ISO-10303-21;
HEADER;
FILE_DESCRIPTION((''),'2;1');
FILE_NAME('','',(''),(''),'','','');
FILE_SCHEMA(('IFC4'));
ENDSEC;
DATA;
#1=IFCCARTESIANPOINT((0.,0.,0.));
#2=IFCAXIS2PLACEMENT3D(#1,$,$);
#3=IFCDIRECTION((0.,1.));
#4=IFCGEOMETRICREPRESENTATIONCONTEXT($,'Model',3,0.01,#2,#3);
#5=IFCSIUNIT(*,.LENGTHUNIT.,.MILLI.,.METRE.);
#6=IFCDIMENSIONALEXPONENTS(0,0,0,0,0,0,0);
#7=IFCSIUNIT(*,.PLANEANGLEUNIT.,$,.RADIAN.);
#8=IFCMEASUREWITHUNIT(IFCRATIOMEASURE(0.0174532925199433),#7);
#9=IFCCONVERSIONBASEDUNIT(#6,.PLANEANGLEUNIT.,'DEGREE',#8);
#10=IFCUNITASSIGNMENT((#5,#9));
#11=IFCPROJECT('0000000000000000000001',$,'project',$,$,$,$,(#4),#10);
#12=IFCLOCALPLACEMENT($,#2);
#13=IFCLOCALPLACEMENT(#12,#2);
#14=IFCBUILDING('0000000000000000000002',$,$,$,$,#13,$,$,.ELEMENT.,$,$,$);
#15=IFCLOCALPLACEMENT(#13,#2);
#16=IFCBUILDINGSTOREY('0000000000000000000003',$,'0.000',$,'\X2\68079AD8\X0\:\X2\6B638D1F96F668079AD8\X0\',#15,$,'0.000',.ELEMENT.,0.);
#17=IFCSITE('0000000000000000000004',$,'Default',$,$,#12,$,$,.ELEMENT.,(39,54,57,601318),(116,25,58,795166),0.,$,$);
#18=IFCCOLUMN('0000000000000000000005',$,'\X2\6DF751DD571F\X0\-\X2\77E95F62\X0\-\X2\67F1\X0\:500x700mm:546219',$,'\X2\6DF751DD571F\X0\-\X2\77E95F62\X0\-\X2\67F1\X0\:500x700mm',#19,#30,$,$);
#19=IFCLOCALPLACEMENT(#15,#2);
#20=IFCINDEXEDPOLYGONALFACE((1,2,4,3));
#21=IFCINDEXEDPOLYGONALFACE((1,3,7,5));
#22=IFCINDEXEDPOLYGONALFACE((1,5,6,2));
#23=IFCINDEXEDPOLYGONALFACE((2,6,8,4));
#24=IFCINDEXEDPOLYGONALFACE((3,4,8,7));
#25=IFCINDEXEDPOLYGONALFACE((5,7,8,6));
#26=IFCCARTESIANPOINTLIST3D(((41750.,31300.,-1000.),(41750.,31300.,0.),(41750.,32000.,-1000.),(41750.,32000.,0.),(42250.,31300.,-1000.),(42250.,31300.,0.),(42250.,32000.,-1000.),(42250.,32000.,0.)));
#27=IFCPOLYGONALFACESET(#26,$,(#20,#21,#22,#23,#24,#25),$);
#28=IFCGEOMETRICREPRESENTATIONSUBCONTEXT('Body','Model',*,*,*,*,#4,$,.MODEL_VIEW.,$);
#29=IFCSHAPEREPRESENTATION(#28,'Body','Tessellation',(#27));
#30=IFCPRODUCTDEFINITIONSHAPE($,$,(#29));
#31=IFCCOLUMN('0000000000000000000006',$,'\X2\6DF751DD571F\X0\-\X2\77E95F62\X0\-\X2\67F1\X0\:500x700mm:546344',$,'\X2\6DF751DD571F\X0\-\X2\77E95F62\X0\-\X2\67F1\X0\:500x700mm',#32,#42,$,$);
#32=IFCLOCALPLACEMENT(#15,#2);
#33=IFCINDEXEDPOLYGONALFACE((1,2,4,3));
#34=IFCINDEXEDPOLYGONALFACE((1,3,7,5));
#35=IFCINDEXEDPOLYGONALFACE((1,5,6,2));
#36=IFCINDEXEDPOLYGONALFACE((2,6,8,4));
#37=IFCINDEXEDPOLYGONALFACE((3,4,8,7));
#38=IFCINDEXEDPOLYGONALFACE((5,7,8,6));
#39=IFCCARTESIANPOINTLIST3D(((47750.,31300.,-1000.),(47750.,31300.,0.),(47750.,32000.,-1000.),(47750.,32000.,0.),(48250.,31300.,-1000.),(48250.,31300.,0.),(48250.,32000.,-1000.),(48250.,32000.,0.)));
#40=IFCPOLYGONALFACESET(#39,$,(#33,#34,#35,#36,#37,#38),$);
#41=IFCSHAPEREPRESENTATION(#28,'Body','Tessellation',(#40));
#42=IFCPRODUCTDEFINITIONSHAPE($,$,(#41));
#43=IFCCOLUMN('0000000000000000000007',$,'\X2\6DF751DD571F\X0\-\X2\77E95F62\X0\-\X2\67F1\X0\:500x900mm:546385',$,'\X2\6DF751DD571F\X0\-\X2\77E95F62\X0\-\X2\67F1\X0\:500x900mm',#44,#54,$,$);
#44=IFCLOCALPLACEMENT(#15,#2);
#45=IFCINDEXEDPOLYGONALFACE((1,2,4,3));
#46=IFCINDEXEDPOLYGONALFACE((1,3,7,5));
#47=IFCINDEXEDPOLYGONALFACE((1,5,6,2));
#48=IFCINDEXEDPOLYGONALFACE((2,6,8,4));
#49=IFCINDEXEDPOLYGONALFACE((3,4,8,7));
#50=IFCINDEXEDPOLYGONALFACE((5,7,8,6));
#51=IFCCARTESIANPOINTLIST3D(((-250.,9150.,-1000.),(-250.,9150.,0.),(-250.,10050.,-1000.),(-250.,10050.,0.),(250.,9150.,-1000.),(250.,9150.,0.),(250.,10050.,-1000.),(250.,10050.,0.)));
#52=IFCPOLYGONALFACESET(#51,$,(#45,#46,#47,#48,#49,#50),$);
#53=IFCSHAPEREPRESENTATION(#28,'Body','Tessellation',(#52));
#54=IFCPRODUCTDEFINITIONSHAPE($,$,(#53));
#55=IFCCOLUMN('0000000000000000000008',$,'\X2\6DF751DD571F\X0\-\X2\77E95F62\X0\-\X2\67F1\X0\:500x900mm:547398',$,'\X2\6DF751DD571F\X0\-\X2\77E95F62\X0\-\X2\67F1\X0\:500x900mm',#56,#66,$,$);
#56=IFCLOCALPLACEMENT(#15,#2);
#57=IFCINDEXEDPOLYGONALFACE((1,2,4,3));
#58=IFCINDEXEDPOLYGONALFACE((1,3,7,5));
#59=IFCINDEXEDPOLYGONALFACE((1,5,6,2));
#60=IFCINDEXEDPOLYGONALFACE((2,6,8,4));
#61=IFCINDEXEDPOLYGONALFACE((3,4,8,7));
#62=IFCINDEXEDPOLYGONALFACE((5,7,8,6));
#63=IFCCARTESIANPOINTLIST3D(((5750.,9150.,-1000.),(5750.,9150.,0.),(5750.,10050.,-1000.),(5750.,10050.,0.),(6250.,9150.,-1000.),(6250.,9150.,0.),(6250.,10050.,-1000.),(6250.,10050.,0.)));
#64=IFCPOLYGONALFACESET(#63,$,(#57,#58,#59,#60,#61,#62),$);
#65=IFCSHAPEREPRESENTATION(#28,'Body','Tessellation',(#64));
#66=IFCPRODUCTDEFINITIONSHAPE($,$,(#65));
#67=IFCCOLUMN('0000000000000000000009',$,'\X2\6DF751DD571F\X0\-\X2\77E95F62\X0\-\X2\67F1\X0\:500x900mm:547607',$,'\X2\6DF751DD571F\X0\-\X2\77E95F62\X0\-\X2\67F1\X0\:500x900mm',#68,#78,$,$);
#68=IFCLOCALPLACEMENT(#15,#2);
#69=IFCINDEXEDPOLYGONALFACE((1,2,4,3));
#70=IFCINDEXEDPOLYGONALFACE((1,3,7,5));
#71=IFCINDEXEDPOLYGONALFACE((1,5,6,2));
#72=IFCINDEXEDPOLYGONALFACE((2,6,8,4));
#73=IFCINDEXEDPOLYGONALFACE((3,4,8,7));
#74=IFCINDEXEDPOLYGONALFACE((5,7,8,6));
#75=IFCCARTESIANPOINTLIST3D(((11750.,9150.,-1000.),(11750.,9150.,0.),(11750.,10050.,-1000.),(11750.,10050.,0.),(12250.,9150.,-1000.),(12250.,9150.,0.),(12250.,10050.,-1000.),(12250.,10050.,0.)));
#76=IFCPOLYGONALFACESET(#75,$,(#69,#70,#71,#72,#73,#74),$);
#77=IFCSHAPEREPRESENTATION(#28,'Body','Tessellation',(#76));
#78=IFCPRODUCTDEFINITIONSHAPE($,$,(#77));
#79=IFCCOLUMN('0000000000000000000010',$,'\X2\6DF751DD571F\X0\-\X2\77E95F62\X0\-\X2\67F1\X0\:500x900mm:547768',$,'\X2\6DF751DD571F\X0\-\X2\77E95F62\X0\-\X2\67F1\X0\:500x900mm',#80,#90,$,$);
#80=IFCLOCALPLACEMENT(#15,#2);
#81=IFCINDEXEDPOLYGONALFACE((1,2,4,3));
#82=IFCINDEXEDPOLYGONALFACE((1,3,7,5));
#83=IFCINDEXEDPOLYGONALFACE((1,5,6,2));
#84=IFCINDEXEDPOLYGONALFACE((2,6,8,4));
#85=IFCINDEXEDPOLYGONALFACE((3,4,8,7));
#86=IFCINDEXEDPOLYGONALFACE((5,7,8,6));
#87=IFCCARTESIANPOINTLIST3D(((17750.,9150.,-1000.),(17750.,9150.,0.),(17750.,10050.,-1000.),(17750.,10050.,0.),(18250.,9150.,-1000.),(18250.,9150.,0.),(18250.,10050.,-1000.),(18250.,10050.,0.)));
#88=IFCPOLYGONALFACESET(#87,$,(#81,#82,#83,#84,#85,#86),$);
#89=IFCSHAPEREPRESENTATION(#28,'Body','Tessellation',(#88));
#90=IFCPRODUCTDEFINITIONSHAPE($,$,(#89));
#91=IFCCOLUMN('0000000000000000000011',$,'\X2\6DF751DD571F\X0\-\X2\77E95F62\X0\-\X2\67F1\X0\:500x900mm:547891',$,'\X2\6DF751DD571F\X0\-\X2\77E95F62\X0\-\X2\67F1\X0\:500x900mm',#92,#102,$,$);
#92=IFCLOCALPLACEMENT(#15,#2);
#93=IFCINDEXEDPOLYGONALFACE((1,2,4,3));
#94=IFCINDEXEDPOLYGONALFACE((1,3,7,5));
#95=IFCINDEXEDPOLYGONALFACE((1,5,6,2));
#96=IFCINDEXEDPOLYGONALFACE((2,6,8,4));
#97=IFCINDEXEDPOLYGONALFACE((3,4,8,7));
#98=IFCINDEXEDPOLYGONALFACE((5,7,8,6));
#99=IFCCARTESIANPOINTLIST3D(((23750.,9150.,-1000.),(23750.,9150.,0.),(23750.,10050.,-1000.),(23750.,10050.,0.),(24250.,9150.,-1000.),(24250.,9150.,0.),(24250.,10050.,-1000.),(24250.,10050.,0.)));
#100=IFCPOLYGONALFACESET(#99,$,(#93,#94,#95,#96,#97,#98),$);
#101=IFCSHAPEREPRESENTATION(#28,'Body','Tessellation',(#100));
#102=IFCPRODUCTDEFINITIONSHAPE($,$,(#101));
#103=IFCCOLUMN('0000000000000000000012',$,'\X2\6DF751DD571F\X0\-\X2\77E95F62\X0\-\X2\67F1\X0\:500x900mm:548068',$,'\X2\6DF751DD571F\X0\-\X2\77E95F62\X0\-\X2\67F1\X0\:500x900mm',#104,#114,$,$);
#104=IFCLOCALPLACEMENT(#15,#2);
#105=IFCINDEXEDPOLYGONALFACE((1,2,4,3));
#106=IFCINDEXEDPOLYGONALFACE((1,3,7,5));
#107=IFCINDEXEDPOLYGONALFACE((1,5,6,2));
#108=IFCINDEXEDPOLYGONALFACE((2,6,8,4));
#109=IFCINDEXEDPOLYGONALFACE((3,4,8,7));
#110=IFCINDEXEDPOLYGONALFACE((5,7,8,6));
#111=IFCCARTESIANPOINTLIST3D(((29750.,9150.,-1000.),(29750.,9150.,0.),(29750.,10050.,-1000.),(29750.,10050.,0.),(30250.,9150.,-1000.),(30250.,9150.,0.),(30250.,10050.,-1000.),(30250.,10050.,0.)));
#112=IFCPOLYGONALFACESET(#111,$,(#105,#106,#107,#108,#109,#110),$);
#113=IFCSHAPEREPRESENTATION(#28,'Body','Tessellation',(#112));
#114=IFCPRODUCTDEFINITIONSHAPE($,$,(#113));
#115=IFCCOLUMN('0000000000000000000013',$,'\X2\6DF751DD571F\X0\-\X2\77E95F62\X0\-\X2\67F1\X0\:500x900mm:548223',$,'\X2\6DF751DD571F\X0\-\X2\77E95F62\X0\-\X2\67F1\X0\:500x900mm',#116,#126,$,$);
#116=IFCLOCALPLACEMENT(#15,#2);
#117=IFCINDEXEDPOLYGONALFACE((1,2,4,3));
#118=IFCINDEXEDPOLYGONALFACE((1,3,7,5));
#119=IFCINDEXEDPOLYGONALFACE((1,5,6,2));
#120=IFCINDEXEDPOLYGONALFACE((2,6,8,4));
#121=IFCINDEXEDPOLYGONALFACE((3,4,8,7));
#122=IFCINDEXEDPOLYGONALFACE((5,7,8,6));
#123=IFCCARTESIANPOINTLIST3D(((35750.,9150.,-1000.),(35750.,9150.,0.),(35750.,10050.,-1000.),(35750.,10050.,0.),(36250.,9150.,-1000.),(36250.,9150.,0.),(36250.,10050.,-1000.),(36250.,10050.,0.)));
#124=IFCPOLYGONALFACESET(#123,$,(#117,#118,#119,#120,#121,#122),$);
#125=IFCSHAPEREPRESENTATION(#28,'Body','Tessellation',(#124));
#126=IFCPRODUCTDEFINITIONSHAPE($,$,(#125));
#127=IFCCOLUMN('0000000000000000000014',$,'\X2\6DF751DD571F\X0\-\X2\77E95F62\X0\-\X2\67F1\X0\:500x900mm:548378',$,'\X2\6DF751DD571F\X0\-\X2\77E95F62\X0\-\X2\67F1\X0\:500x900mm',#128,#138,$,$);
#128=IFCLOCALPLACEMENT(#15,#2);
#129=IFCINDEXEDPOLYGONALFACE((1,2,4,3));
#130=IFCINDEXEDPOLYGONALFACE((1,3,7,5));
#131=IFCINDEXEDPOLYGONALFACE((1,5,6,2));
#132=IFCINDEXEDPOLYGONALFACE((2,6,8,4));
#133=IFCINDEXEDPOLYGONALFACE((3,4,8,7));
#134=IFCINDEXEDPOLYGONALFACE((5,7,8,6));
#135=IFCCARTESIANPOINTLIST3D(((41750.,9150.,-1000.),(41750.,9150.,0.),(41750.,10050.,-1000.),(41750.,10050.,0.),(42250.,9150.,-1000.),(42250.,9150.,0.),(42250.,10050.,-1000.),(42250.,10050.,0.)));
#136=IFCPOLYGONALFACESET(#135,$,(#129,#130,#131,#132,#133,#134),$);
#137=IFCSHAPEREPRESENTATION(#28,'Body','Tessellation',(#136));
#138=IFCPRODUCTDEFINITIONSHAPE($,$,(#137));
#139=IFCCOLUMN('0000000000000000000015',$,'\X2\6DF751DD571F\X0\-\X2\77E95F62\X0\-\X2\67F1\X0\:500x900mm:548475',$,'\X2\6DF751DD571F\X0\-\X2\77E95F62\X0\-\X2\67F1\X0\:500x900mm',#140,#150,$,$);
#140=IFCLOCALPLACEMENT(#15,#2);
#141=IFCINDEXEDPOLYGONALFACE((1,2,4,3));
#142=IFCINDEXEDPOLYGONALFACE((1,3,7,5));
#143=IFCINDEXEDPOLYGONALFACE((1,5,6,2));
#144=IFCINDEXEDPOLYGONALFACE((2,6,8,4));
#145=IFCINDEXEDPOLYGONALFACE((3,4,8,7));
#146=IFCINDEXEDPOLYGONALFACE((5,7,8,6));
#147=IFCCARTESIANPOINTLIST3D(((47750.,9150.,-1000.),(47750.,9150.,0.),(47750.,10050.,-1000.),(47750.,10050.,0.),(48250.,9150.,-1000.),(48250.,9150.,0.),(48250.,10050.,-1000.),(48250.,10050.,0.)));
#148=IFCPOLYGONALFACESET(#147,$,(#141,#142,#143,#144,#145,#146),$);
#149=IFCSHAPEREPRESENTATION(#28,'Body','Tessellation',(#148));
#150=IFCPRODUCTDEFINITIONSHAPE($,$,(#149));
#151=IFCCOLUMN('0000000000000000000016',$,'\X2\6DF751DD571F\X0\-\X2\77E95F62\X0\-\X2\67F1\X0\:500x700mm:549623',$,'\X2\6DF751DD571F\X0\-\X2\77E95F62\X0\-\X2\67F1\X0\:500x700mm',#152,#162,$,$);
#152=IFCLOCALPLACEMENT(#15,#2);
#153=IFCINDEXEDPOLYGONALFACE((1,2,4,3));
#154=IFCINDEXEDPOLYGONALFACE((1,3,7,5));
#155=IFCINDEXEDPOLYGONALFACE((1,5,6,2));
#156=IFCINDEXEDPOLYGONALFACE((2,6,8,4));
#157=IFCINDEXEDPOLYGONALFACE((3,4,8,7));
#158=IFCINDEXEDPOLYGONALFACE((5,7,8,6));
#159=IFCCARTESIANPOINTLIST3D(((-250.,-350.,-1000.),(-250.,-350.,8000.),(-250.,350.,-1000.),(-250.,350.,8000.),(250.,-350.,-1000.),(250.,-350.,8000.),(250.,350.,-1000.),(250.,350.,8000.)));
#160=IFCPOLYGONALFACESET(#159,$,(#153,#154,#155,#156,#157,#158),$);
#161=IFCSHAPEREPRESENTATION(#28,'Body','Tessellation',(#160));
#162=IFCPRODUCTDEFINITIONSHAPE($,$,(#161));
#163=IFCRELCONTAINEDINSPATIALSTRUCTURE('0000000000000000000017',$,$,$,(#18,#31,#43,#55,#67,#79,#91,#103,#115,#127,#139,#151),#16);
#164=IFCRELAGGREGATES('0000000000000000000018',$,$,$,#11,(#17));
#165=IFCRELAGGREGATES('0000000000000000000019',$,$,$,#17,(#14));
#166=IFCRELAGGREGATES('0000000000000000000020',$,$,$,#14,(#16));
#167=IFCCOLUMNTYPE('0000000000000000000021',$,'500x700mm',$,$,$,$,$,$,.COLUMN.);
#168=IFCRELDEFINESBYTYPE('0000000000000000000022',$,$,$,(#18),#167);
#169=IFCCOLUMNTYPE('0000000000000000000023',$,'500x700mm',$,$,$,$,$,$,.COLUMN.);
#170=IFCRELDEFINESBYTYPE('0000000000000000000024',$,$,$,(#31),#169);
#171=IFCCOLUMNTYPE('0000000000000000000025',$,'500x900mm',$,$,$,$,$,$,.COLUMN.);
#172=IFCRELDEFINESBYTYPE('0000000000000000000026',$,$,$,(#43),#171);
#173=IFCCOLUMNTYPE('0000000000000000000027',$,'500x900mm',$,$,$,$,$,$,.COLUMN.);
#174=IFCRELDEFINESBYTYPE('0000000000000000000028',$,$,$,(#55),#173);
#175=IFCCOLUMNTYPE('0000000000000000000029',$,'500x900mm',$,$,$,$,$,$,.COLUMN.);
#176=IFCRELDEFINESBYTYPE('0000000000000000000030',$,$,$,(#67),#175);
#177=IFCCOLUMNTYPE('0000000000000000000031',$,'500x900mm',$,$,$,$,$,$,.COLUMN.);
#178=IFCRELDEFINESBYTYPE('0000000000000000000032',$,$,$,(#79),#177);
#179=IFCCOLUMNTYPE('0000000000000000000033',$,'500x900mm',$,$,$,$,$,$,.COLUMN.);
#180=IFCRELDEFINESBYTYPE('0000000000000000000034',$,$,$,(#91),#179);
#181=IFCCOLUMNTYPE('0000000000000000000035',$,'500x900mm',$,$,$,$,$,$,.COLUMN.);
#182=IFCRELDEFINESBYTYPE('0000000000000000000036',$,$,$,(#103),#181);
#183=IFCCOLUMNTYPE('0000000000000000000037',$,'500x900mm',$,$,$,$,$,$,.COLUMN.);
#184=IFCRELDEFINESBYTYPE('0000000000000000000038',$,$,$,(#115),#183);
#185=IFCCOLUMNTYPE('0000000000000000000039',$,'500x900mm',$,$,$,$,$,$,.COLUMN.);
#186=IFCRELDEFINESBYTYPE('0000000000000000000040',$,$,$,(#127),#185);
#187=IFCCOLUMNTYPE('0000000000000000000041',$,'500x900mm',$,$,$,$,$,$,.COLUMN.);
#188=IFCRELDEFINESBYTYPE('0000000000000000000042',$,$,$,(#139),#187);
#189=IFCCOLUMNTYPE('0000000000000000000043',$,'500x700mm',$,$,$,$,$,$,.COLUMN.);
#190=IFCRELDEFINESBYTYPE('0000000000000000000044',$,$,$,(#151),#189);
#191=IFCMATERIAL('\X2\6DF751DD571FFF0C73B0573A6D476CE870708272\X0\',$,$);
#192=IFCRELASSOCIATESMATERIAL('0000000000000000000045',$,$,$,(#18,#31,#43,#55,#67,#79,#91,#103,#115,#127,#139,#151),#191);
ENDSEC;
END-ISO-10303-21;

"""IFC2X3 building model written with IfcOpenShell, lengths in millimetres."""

from ifc_helpers import new_model, entity, si_unit, converted_unit, direction, frame, frame_2d, origin, origin_2d_with_axis, place, context, subcontext, project, spatial, rectangle, extrude, source, transform, mapped, material, type_object, type_shapes, element, save


model = new_model("IFC2X3")

# Units and contexts
model_context = context("Model", 3, precision=0.01, world=origin(), true_north=direction((0.0, 1.0)))
body_context = subcontext(model_context, "Body", "Model", "MODEL_VIEW")
ifc_project = project(units=[si_unit("LENGTHUNIT", "METRE", prefix="MILLI"), converted_unit("PLANEANGLEUNIT", "DEGREE", entity("IfcRatioMeasure", 0.0174532925199433), si_unit("PLANEANGLEUNIT", "RADIAN"), dimensions=[0, 0, 0, 0, 0, 0, 0])], contexts=[model_context])

# Site, building, storey
site_placement = place(None, origin())
site = spatial("IfcSite", under=ifc_project, at=site_placement, Name="Default", CompositionType="ELEMENT", RefLatitude=(39, 54, 57, 601318), RefLongitude=(116, 25, 58, 795166), RefElevation=0.0)
building_placement = place(site_placement, origin())
building = spatial("IfcBuilding", under=site, at=building_placement, CompositionType="ELEMENT")
storey_placement = place(building_placement, origin())
storey = spatial("IfcBuildingStorey", under=building, at=storey_placement, Name="0.000", ObjectType="标高:正负零标高", LongName="0.000", CompositionType="ELEMENT", Elevation=0.0)

# Columns
ifc_material_1 = material(Name="混凝土，现场浇注灰色")
column_type_1 = type_object("IfcColumnType", Name="500x700mm", PredefinedType="COLUMN")
shared_shape_1 = source(origin(), body_context, "Body", "SweptSolid", [
    extrude(rectangle(XDim=700.0, YDim=500.0, at=origin_2d_with_axis()), frame((42000.0, 31650.0, -1000.0), z_axis=(0.0, 0.0, 1.0), x_axis=(0.0, -1.0, 0.0)), (0.0, 0.0, 1.0), 1000.0),
])
type_shapes(column_type_1, [shared_shape_1])
column_1_placement = place(storey_placement, origin())
element("IfcColumn", 1, at=column_1_placement, inside=storey, type_object=column_type_1, material=ifc_material_1, Name="混凝土-矩形-柱:500x700mm:546219", ObjectType="混凝土-矩形-柱:500x700mm", context=body_context, shape_type="MappedRepresentation", body=[
    mapped(shared_shape_1, transform((0.0, 0.0, 0.0), scale=1.0)),
])
column_type_2 = type_object("IfcColumnType", Name="500x700mm", PredefinedType="COLUMN")
shared_shape_2 = source(origin(), body_context, "Body", "SweptSolid", [
    extrude(rectangle(XDim=700.0, YDim=500.0, at=origin_2d_with_axis()), frame((48000.0, 31650.0, -1000.0), z_axis=(0.0, 0.0, 1.0), x_axis=(0.0, -1.0, 0.0)), (0.0, 0.0, 1.0), 1000.0),
])
type_shapes(column_type_2, [shared_shape_2])
column_2_placement = place(storey_placement, origin())
element("IfcColumn", 2, at=column_2_placement, inside=storey, type_object=column_type_2, material=ifc_material_1, Name="混凝土-矩形-柱:500x700mm:546344", ObjectType="混凝土-矩形-柱:500x700mm", context=body_context, shape_type="MappedRepresentation", body=[
    mapped(shared_shape_2, transform((0.0, 0.0, 0.0), scale=1.0)),
])
column_type_3 = type_object("IfcColumnType", Name="500x900mm", PredefinedType="COLUMN")
shared_shape_3 = source(origin(), body_context, "Body", "SweptSolid", [
    extrude(rectangle(XDim=900.0, YDim=500.0, at=origin_2d_with_axis()), frame((0.0, 9600.0, -1000.0), z_axis=(0.0, 0.0, 1.0), x_axis=(0.0, -1.0, 0.0)), (0.0, 0.0, 1.0), 1000.0),
])
type_shapes(column_type_3, [shared_shape_3])
column_3_placement = place(storey_placement, origin())
element("IfcColumn", 3, at=column_3_placement, inside=storey, type_object=column_type_3, material=ifc_material_1, Name="混凝土-矩形-柱:500x900mm:546385", ObjectType="混凝土-矩形-柱:500x900mm", context=body_context, shape_type="MappedRepresentation", body=[
    mapped(shared_shape_3, transform((0.0, 0.0, 0.0), scale=1.0)),
])
column_type_4 = type_object("IfcColumnType", Name="500x900mm", PredefinedType="COLUMN")
shared_shape_4 = source(origin(), body_context, "Body", "SweptSolid", [
    extrude(rectangle(XDim=900.0, YDim=500.0, at=frame_2d((0.0, 0.0), x_axis=(1.0, 0.0))), frame((6000.0, 9600.0, -1000.0), z_axis=(0.0, 0.0, 1.0), x_axis=(0.0, -1.0, 0.0)), (0.0, 0.0, 1.0), 1000.0),
])
type_shapes(column_type_4, [shared_shape_4])
column_4_placement = place(storey_placement, origin())
element("IfcColumn", 4, at=column_4_placement, inside=storey, type_object=column_type_4, material=ifc_material_1, Name="混凝土-矩形-柱:500x900mm:547398", ObjectType="混凝土-矩形-柱:500x900mm", context=body_context, shape_type="MappedRepresentation", body=[
    mapped(shared_shape_4, transform((0.0, 0.0, 0.0), scale=1.0)),
])
column_type_5 = type_object("IfcColumnType", Name="500x900mm", PredefinedType="COLUMN")
shared_shape_5 = source(origin(), body_context, "Body", "SweptSolid", [
    extrude(rectangle(XDim=900.0, YDim=500.0, at=origin_2d_with_axis()), frame((12000.0, 9600.0, -1000.0), z_axis=(0.0, 0.0, 1.0), x_axis=(0.0, -1.0, 0.0)), (0.0, 0.0, 1.0), 1000.0),
])
type_shapes(column_type_5, [shared_shape_5])
column_5_placement = place(storey_placement, origin())
element("IfcColumn", 5, at=column_5_placement, inside=storey, type_object=column_type_5, material=ifc_material_1, Name="混凝土-矩形-柱:500x900mm:547607", ObjectType="混凝土-矩形-柱:500x900mm", context=body_context, shape_type="MappedRepresentation", body=[
    mapped(shared_shape_5, transform((0.0, 0.0, 0.0), scale=1.0)),
])
column_type_6 = type_object("IfcColumnType", Name="500x900mm", PredefinedType="COLUMN")
shared_shape_6 = source(origin(), body_context, "Body", "SweptSolid", [
    extrude(rectangle(XDim=900.0, YDim=500.0, at=origin_2d_with_axis()), frame((18000.0, 9600.0, -1000.0), z_axis=(0.0, 0.0, 1.0), x_axis=(0.0, -1.0, 0.0)), (0.0, 0.0, 1.0), 1000.0),
])
type_shapes(column_type_6, [shared_shape_6])
column_6_placement = place(storey_placement, origin())
element("IfcColumn", 6, at=column_6_placement, inside=storey, type_object=column_type_6, material=ifc_material_1, Name="混凝土-矩形-柱:500x900mm:547768", ObjectType="混凝土-矩形-柱:500x900mm", context=body_context, shape_type="MappedRepresentation", body=[
    mapped(shared_shape_6, transform((0.0, 0.0, 0.0), scale=1.0)),
])
column_type_7 = type_object("IfcColumnType", Name="500x900mm", PredefinedType="COLUMN")
shared_shape_7 = source(origin(), body_context, "Body", "SweptSolid", [
    extrude(rectangle(XDim=900.0, YDim=500.0, at=origin_2d_with_axis()), frame((24000.0, 9600.0, -1000.0), z_axis=(0.0, 0.0, 1.0), x_axis=(0.0, -1.0, 0.0)), (0.0, 0.0, 1.0), 1000.0),
])
type_shapes(column_type_7, [shared_shape_7])
column_7_placement = place(storey_placement, origin())
element("IfcColumn", 7, at=column_7_placement, inside=storey, type_object=column_type_7, material=ifc_material_1, Name="混凝土-矩形-柱:500x900mm:547891", ObjectType="混凝土-矩形-柱:500x900mm", context=body_context, shape_type="MappedRepresentation", body=[
    mapped(shared_shape_7, transform((0.0, 0.0, 0.0), scale=1.0)),
])
column_type_8 = type_object("IfcColumnType", Name="500x900mm", PredefinedType="COLUMN")
shared_shape_8 = source(origin(), body_context, "Body", "SweptSolid", [
    extrude(rectangle(XDim=900.0, YDim=500.0, at=origin_2d_with_axis()), frame((30000.0, 9600.0, -1000.0), z_axis=(0.0, 0.0, 1.0), x_axis=(0.0, -1.0, 0.0)), (0.0, 0.0, 1.0), 1000.0),
])
type_shapes(column_type_8, [shared_shape_8])
column_8_placement = place(storey_placement, origin())
element("IfcColumn", 8, at=column_8_placement, inside=storey, type_object=column_type_8, material=ifc_material_1, Name="混凝土-矩形-柱:500x900mm:548068", ObjectType="混凝土-矩形-柱:500x900mm", context=body_context, shape_type="MappedRepresentation", body=[
    mapped(shared_shape_8, transform((0.0, 0.0, 0.0), scale=1.0)),
])
column_type_9 = type_object("IfcColumnType", Name="500x900mm", PredefinedType="COLUMN")
shared_shape_9 = source(origin(), body_context, "Body", "SweptSolid", [
    extrude(rectangle(XDim=900.0, YDim=500.0, at=origin_2d_with_axis()), frame((36000.0, 9600.0, -1000.0), z_axis=(0.0, 0.0, 1.0), x_axis=(0.0, -1.0, 0.0)), (0.0, 0.0, 1.0), 1000.0),
])
type_shapes(column_type_9, [shared_shape_9])
column_9_placement = place(storey_placement, origin())
element("IfcColumn", 9, at=column_9_placement, inside=storey, type_object=column_type_9, material=ifc_material_1, Name="混凝土-矩形-柱:500x900mm:548223", ObjectType="混凝土-矩形-柱:500x900mm", context=body_context, shape_type="MappedRepresentation", body=[
    mapped(shared_shape_9, transform((0.0, 0.0, 0.0), scale=1.0)),
])
column_type_10 = type_object("IfcColumnType", Name="500x900mm", PredefinedType="COLUMN")
shared_shape_10 = source(origin(), body_context, "Body", "SweptSolid", [
    extrude(rectangle(XDim=900.0, YDim=500.0, at=origin_2d_with_axis()), frame((42000.0, 9600.0, -1000.0), z_axis=(0.0, 0.0, 1.0), x_axis=(0.0, -1.0, 0.0)), (0.0, 0.0, 1.0), 1000.0),
])
type_shapes(column_type_10, [shared_shape_10])
column_10_placement = place(storey_placement, origin())
element("IfcColumn", 10, at=column_10_placement, inside=storey, type_object=column_type_10, material=ifc_material_1, Name="混凝土-矩形-柱:500x900mm:548378", ObjectType="混凝土-矩形-柱:500x900mm", context=body_context, shape_type="MappedRepresentation", body=[
    mapped(shared_shape_10, transform((0.0, 0.0, 0.0), scale=1.0)),
])
column_type_11 = type_object("IfcColumnType", Name="500x900mm", PredefinedType="COLUMN")
shared_shape_11 = source(origin(), body_context, "Body", "SweptSolid", [
    extrude(rectangle(XDim=900.0, YDim=500.0, at=origin_2d_with_axis()), frame((48000.0, 9600.0, -1000.0), z_axis=(0.0, 0.0, 1.0), x_axis=(0.0, -1.0, 0.0)), (0.0, 0.0, 1.0), 1000.0),
])
type_shapes(column_type_11, [shared_shape_11])
column_11_placement = place(storey_placement, origin())
element("IfcColumn", 11, at=column_11_placement, inside=storey, type_object=column_type_11, material=ifc_material_1, Name="混凝土-矩形-柱:500x900mm:548475", ObjectType="混凝土-矩形-柱:500x900mm", context=body_context, shape_type="MappedRepresentation", body=[
    mapped(shared_shape_11, transform((0.0, 0.0, 0.0), scale=1.0)),
])
column_type_12 = type_object("IfcColumnType", Name="500x700mm", PredefinedType="COLUMN")
shared_shape_12 = source(origin(), body_context, "Body", "SweptSolid", [
    extrude(rectangle(XDim=700.0, YDim=500.0, at=origin_2d_with_axis()), frame((0.0, 0.0, -1000.0), z_axis=(0.0, 0.0, 1.0), x_axis=(0.0, -1.0, 0.0)), (0.0, 0.0, 1.0), 9000.0),
])
type_shapes(column_type_12, [shared_shape_12])
column_12_placement = place(storey_placement, origin())
element("IfcColumn", 12, at=column_12_placement, inside=storey, type_object=column_type_12, material=ifc_material_1, Name="混凝土-矩形-柱:500x700mm:549623", ObjectType="混凝土-矩形-柱:500x700mm", context=body_context, shape_type="MappedRepresentation", body=[
    mapped(shared_shape_12, transform((0.0, 0.0, 0.0), scale=1.0)),
])

save(model, "model.ifc")
